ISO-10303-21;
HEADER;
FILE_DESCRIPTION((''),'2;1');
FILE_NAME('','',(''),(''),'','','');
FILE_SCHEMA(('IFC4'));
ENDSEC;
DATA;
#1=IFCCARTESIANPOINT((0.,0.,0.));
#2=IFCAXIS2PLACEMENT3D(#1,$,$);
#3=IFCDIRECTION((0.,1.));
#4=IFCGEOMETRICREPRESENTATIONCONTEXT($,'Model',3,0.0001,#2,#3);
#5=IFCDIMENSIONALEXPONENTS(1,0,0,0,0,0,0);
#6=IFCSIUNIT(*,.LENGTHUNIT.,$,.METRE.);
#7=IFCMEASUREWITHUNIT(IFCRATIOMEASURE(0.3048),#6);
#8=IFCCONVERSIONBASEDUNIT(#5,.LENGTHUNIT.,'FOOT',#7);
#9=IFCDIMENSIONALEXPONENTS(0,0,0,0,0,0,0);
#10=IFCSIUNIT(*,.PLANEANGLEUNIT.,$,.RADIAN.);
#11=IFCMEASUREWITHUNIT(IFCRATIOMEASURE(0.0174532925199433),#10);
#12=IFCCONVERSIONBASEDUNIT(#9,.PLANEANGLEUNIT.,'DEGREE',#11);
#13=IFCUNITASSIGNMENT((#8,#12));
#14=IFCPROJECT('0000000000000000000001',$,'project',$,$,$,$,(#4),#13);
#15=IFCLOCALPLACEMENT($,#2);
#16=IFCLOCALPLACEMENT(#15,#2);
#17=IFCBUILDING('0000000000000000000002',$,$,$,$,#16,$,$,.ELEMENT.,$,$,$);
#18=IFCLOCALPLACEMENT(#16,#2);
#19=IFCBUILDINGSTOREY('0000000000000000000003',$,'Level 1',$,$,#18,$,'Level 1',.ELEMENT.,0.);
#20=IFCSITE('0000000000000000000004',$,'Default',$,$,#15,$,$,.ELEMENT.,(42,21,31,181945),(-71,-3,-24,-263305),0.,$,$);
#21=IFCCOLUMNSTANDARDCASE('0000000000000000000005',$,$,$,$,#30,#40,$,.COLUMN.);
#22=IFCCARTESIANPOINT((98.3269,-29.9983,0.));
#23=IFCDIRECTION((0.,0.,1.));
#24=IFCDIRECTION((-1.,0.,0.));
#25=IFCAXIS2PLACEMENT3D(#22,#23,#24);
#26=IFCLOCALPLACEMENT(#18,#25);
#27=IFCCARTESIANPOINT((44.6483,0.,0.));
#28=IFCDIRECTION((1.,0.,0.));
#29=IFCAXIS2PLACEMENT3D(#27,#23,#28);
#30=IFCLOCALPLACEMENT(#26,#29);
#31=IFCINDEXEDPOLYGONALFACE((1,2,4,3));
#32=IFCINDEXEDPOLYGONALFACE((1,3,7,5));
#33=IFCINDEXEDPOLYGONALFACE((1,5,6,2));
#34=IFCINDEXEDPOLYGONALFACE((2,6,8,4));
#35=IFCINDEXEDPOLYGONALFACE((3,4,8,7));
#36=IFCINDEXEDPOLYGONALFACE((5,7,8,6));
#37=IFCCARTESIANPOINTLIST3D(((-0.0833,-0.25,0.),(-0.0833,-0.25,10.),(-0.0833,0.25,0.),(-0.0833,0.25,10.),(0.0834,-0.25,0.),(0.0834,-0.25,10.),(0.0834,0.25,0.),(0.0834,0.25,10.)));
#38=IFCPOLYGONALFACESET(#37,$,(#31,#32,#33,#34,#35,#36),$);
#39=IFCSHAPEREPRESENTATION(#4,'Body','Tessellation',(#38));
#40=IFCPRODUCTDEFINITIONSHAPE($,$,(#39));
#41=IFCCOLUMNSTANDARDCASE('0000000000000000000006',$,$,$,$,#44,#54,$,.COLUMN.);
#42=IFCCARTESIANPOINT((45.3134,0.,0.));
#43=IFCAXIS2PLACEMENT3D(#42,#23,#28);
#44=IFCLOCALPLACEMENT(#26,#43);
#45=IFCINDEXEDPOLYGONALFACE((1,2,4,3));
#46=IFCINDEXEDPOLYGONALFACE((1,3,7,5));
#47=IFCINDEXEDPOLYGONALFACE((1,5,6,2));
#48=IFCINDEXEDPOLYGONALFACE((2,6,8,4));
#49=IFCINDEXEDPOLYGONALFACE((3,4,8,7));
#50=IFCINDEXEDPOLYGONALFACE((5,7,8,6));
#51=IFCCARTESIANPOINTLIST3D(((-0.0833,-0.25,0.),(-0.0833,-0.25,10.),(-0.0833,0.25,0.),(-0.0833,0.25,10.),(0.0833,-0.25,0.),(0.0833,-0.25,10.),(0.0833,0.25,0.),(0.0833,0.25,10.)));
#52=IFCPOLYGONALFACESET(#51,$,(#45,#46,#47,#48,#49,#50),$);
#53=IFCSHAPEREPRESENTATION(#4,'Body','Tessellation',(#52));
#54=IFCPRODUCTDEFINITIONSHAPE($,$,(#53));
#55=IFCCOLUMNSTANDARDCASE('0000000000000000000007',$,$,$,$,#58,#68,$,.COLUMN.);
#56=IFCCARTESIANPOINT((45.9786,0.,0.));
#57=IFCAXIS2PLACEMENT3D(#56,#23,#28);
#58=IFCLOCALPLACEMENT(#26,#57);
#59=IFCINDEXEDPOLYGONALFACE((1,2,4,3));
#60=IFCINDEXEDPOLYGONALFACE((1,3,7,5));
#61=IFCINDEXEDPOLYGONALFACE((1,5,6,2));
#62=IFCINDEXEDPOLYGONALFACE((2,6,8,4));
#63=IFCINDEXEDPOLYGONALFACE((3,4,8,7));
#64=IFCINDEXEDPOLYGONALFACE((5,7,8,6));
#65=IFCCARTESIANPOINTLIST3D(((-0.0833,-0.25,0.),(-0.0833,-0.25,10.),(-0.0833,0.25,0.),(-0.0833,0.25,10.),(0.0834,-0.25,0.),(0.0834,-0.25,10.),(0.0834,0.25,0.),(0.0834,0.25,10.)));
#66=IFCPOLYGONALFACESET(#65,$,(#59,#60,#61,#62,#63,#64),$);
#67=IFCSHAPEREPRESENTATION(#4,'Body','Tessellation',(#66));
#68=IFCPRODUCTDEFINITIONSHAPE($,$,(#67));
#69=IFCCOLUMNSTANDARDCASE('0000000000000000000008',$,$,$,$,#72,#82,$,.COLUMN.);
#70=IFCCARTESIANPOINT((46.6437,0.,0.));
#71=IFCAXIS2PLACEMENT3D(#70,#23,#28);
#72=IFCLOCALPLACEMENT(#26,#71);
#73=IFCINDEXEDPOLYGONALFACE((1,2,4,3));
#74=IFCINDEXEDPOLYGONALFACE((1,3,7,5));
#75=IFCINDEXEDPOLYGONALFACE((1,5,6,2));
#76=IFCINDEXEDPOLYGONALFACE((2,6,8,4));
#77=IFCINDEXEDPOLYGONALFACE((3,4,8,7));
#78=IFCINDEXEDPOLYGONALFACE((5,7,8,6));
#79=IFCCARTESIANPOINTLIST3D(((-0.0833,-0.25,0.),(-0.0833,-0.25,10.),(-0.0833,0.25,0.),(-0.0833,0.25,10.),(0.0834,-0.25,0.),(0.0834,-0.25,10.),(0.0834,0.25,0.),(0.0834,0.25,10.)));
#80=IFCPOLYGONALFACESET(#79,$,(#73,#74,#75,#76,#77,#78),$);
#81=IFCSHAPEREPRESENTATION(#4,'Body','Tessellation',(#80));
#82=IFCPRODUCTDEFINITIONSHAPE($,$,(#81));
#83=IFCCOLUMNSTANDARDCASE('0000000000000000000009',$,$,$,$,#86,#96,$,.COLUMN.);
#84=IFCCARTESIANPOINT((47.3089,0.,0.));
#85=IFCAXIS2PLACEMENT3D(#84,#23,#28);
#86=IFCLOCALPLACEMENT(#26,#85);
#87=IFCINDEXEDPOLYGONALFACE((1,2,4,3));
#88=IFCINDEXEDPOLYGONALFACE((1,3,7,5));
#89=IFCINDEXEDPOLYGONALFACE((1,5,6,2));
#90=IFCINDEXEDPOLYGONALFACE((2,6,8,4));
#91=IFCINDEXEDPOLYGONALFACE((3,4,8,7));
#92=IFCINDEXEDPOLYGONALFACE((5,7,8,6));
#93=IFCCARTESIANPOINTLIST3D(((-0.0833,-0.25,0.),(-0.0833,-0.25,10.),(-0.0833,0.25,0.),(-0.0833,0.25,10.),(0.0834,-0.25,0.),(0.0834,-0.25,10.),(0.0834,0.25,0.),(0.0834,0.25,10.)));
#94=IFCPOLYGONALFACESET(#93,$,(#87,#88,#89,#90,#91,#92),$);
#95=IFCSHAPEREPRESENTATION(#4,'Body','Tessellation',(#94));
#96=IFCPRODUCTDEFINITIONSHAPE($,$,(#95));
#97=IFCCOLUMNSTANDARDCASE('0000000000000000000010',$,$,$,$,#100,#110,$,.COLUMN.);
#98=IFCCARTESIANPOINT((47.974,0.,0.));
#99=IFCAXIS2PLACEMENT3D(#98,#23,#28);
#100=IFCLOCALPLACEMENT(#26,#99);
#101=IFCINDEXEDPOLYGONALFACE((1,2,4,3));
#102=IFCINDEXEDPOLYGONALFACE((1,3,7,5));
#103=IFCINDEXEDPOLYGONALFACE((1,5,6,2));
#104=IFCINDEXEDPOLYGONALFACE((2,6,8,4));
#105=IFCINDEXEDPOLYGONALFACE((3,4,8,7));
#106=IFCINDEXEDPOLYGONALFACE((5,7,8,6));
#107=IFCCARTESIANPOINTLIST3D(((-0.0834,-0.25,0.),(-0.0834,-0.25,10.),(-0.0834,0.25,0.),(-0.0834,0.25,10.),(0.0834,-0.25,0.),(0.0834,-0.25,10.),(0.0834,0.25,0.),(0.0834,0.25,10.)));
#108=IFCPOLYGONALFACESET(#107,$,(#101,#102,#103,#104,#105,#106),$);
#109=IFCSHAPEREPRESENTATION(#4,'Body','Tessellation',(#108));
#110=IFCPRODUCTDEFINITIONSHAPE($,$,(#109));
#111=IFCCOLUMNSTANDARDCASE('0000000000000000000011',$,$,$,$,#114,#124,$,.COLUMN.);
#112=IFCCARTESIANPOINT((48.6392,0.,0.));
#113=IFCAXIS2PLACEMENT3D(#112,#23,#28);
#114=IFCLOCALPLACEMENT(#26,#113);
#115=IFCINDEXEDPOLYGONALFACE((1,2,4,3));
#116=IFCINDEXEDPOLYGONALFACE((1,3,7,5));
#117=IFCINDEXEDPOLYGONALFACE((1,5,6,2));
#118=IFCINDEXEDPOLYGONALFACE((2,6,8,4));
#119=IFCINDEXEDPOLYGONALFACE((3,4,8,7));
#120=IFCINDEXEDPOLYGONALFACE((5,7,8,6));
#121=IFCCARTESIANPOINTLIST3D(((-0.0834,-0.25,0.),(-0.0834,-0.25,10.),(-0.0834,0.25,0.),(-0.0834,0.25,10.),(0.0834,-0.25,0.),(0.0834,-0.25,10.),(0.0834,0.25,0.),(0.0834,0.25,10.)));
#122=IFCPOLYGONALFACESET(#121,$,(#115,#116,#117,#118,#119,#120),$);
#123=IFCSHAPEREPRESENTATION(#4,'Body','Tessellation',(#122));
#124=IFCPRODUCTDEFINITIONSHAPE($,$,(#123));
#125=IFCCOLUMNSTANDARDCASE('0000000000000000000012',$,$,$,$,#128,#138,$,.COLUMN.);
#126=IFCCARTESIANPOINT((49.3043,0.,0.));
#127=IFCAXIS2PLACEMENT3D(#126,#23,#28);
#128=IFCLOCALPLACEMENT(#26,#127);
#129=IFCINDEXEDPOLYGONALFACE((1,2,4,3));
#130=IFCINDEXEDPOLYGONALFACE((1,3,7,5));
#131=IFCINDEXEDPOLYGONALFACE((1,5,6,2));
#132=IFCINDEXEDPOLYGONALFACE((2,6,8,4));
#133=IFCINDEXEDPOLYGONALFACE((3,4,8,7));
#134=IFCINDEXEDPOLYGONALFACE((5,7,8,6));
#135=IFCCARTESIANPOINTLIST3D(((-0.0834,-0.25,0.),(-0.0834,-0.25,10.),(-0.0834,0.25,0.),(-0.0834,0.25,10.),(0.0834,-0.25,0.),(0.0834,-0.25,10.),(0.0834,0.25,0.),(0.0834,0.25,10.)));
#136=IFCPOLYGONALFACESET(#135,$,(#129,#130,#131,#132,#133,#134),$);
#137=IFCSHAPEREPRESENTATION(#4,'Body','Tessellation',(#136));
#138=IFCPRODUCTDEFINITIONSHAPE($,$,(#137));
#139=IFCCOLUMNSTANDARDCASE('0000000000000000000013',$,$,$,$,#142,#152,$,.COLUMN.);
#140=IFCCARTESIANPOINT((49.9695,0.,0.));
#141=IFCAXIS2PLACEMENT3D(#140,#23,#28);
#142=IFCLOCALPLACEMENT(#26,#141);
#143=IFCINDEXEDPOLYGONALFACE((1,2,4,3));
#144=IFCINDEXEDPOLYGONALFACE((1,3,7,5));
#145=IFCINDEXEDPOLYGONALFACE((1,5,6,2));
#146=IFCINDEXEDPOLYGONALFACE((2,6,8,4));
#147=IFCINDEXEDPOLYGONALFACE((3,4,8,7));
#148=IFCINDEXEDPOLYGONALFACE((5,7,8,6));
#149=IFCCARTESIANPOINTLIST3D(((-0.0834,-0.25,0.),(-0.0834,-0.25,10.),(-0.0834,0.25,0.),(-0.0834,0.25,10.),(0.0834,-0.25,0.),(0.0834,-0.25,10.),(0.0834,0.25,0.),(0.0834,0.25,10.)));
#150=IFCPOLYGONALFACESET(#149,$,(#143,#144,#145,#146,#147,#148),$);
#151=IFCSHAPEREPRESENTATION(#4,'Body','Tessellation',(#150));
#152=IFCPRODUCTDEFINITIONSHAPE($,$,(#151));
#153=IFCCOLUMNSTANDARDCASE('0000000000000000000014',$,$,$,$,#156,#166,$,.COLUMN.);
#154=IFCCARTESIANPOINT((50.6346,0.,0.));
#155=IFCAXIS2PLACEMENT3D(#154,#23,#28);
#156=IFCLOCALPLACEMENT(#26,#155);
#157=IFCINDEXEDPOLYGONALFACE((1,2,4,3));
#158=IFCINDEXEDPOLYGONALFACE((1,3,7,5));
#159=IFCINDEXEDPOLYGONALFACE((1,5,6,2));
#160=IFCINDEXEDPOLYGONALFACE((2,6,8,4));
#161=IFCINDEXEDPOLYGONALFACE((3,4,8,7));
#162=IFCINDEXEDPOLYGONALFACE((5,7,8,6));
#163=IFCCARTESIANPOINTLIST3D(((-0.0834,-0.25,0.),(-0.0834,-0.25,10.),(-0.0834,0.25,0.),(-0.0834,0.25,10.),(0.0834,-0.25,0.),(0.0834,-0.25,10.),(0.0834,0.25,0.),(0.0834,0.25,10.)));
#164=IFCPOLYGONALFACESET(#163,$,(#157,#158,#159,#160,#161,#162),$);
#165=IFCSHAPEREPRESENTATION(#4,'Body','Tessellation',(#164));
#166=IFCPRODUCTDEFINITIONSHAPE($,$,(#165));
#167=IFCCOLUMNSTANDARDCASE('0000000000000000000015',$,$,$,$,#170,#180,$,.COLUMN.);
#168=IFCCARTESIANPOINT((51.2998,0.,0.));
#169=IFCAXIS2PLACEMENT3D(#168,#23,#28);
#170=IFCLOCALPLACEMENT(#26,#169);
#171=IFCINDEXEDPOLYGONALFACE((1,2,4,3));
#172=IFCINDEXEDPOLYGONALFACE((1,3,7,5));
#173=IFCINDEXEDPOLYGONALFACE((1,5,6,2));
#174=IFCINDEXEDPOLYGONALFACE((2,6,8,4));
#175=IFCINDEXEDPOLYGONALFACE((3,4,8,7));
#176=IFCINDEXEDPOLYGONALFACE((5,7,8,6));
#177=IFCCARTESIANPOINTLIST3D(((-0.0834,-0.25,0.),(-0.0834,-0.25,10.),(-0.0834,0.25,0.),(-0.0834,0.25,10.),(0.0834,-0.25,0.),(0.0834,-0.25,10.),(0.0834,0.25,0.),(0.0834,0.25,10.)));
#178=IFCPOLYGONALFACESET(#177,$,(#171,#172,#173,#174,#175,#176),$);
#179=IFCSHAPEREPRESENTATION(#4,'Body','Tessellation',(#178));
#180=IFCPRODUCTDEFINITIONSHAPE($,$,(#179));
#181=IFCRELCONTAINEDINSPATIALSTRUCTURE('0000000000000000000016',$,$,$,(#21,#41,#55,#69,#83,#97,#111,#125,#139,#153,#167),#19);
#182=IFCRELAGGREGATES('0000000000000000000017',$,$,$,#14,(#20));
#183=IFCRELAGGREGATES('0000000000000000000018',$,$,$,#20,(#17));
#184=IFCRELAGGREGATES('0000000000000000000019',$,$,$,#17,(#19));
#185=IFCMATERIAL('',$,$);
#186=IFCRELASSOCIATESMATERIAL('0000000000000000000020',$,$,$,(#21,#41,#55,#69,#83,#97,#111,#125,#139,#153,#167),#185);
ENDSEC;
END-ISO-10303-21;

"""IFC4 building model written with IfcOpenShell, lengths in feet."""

from ifc_helpers import new_model, entity, si_unit, converted_unit, direction, frame, origin, place, context, project, spatial, rectangle, extrude, material, element, save


model = new_model("IFC4")

# Units and contexts
model_context = context("Model", 3, precision=0.0001, world=origin(), true_north=direction((0.0, 1.0)))
ifc_project = project(units=[converted_unit("LENGTHUNIT", "FOOT", entity("IfcRatioMeasure", 0.3048), si_unit("LENGTHUNIT", "METRE"), dimensions=[1, 0, 0, 0, 0, 0, 0]), converted_unit("PLANEANGLEUNIT", "DEGREE", entity("IfcRatioMeasure", 0.0174532925199433), si_unit("PLANEANGLEUNIT", "RADIAN"), dimensions=[0, 0, 0, 0, 0, 0, 0])], contexts=[model_context])

# Site, building, storey
site_placement = place(None, origin())
site = spatial("IfcSite", under=ifc_project, at=site_placement, Name="Default", CompositionType="ELEMENT", RefLatitude=(42, 21, 31, 181945), RefLongitude=(-71, -3, -24, -263305), RefElevation=0.0)
building_placement = place(site_placement, origin())
building = spatial("IfcBuilding", under=site, at=building_placement, CompositionType="ELEMENT")
storey_placement = place(building_placement, origin())
storey = spatial("IfcBuildingStorey", under=building, at=storey_placement, Name="Level 1", LongName="Level 1", CompositionType="ELEMENT", Elevation=0.0)

# Columns
ifc_material = material(Name="")
placement = place(storey_placement, frame((98.3269, -29.9983, 0.0), z_axis=(0.0, 0.0, 1.0), x_axis=(-1.0, 0.0, 0.0)))
for number, where, z_axis, x_axis in (
    (1, (44.6483, 0.0, 0.0), (0.0, 0.0, 1.0), (1.0, 0.0, 0.0)),
    (2, (45.3134, 0.0, 0.0), (0.0, 0.0, 1.0), (1.0, 0.0, 0.0)),
    (3, (45.9786, 0.0, 0.0), (0.0, 0.0, 1.0), (1.0, 0.0, 0.0)),
    (4, (46.6437, 0.0, 0.0), (0.0, 0.0, 1.0), (1.0, 0.0, 0.0)),
    (5, (47.3089, 0.0, 0.0), (0.0, 0.0, 1.0), (1.0, 0.0, 0.0)),
    (6, (47.974, 0.0, 0.0), (0.0, 0.0, 1.0), (1.0, 0.0, 0.0)),
    (7, (48.6392, 0.0, 0.0), (0.0, 0.0, 1.0), (1.0, 0.0, 0.0)),
    (8, (49.3043, 0.0, 0.0), (0.0, 0.0, 1.0), (1.0, 0.0, 0.0)),
    (9, (49.9695, 0.0, 0.0), (0.0, 0.0, 1.0), (1.0, 0.0, 0.0)),
    (10, (50.6346, 0.0, 0.0), (0.0, 0.0, 1.0), (1.0, 0.0, 0.0)),
    (11, (51.2998, 0.0, 0.0), (0.0, 0.0, 1.0), (1.0, 0.0, 0.0)),
):
    element("IfcColumnStandardCase", number, at=place(placement, frame(where, z_axis=z_axis, x_axis=x_axis)), inside=storey, material=ifc_material, PredefinedType="COLUMN", context=model_context, shape_type="SweptSolid", body=[
        extrude(rectangle(XDim=0.1667, YDim=0.5), origin(), (0.0, 0.0, 1.0), 10.0),
    ])

save(model, "model.ifc")
